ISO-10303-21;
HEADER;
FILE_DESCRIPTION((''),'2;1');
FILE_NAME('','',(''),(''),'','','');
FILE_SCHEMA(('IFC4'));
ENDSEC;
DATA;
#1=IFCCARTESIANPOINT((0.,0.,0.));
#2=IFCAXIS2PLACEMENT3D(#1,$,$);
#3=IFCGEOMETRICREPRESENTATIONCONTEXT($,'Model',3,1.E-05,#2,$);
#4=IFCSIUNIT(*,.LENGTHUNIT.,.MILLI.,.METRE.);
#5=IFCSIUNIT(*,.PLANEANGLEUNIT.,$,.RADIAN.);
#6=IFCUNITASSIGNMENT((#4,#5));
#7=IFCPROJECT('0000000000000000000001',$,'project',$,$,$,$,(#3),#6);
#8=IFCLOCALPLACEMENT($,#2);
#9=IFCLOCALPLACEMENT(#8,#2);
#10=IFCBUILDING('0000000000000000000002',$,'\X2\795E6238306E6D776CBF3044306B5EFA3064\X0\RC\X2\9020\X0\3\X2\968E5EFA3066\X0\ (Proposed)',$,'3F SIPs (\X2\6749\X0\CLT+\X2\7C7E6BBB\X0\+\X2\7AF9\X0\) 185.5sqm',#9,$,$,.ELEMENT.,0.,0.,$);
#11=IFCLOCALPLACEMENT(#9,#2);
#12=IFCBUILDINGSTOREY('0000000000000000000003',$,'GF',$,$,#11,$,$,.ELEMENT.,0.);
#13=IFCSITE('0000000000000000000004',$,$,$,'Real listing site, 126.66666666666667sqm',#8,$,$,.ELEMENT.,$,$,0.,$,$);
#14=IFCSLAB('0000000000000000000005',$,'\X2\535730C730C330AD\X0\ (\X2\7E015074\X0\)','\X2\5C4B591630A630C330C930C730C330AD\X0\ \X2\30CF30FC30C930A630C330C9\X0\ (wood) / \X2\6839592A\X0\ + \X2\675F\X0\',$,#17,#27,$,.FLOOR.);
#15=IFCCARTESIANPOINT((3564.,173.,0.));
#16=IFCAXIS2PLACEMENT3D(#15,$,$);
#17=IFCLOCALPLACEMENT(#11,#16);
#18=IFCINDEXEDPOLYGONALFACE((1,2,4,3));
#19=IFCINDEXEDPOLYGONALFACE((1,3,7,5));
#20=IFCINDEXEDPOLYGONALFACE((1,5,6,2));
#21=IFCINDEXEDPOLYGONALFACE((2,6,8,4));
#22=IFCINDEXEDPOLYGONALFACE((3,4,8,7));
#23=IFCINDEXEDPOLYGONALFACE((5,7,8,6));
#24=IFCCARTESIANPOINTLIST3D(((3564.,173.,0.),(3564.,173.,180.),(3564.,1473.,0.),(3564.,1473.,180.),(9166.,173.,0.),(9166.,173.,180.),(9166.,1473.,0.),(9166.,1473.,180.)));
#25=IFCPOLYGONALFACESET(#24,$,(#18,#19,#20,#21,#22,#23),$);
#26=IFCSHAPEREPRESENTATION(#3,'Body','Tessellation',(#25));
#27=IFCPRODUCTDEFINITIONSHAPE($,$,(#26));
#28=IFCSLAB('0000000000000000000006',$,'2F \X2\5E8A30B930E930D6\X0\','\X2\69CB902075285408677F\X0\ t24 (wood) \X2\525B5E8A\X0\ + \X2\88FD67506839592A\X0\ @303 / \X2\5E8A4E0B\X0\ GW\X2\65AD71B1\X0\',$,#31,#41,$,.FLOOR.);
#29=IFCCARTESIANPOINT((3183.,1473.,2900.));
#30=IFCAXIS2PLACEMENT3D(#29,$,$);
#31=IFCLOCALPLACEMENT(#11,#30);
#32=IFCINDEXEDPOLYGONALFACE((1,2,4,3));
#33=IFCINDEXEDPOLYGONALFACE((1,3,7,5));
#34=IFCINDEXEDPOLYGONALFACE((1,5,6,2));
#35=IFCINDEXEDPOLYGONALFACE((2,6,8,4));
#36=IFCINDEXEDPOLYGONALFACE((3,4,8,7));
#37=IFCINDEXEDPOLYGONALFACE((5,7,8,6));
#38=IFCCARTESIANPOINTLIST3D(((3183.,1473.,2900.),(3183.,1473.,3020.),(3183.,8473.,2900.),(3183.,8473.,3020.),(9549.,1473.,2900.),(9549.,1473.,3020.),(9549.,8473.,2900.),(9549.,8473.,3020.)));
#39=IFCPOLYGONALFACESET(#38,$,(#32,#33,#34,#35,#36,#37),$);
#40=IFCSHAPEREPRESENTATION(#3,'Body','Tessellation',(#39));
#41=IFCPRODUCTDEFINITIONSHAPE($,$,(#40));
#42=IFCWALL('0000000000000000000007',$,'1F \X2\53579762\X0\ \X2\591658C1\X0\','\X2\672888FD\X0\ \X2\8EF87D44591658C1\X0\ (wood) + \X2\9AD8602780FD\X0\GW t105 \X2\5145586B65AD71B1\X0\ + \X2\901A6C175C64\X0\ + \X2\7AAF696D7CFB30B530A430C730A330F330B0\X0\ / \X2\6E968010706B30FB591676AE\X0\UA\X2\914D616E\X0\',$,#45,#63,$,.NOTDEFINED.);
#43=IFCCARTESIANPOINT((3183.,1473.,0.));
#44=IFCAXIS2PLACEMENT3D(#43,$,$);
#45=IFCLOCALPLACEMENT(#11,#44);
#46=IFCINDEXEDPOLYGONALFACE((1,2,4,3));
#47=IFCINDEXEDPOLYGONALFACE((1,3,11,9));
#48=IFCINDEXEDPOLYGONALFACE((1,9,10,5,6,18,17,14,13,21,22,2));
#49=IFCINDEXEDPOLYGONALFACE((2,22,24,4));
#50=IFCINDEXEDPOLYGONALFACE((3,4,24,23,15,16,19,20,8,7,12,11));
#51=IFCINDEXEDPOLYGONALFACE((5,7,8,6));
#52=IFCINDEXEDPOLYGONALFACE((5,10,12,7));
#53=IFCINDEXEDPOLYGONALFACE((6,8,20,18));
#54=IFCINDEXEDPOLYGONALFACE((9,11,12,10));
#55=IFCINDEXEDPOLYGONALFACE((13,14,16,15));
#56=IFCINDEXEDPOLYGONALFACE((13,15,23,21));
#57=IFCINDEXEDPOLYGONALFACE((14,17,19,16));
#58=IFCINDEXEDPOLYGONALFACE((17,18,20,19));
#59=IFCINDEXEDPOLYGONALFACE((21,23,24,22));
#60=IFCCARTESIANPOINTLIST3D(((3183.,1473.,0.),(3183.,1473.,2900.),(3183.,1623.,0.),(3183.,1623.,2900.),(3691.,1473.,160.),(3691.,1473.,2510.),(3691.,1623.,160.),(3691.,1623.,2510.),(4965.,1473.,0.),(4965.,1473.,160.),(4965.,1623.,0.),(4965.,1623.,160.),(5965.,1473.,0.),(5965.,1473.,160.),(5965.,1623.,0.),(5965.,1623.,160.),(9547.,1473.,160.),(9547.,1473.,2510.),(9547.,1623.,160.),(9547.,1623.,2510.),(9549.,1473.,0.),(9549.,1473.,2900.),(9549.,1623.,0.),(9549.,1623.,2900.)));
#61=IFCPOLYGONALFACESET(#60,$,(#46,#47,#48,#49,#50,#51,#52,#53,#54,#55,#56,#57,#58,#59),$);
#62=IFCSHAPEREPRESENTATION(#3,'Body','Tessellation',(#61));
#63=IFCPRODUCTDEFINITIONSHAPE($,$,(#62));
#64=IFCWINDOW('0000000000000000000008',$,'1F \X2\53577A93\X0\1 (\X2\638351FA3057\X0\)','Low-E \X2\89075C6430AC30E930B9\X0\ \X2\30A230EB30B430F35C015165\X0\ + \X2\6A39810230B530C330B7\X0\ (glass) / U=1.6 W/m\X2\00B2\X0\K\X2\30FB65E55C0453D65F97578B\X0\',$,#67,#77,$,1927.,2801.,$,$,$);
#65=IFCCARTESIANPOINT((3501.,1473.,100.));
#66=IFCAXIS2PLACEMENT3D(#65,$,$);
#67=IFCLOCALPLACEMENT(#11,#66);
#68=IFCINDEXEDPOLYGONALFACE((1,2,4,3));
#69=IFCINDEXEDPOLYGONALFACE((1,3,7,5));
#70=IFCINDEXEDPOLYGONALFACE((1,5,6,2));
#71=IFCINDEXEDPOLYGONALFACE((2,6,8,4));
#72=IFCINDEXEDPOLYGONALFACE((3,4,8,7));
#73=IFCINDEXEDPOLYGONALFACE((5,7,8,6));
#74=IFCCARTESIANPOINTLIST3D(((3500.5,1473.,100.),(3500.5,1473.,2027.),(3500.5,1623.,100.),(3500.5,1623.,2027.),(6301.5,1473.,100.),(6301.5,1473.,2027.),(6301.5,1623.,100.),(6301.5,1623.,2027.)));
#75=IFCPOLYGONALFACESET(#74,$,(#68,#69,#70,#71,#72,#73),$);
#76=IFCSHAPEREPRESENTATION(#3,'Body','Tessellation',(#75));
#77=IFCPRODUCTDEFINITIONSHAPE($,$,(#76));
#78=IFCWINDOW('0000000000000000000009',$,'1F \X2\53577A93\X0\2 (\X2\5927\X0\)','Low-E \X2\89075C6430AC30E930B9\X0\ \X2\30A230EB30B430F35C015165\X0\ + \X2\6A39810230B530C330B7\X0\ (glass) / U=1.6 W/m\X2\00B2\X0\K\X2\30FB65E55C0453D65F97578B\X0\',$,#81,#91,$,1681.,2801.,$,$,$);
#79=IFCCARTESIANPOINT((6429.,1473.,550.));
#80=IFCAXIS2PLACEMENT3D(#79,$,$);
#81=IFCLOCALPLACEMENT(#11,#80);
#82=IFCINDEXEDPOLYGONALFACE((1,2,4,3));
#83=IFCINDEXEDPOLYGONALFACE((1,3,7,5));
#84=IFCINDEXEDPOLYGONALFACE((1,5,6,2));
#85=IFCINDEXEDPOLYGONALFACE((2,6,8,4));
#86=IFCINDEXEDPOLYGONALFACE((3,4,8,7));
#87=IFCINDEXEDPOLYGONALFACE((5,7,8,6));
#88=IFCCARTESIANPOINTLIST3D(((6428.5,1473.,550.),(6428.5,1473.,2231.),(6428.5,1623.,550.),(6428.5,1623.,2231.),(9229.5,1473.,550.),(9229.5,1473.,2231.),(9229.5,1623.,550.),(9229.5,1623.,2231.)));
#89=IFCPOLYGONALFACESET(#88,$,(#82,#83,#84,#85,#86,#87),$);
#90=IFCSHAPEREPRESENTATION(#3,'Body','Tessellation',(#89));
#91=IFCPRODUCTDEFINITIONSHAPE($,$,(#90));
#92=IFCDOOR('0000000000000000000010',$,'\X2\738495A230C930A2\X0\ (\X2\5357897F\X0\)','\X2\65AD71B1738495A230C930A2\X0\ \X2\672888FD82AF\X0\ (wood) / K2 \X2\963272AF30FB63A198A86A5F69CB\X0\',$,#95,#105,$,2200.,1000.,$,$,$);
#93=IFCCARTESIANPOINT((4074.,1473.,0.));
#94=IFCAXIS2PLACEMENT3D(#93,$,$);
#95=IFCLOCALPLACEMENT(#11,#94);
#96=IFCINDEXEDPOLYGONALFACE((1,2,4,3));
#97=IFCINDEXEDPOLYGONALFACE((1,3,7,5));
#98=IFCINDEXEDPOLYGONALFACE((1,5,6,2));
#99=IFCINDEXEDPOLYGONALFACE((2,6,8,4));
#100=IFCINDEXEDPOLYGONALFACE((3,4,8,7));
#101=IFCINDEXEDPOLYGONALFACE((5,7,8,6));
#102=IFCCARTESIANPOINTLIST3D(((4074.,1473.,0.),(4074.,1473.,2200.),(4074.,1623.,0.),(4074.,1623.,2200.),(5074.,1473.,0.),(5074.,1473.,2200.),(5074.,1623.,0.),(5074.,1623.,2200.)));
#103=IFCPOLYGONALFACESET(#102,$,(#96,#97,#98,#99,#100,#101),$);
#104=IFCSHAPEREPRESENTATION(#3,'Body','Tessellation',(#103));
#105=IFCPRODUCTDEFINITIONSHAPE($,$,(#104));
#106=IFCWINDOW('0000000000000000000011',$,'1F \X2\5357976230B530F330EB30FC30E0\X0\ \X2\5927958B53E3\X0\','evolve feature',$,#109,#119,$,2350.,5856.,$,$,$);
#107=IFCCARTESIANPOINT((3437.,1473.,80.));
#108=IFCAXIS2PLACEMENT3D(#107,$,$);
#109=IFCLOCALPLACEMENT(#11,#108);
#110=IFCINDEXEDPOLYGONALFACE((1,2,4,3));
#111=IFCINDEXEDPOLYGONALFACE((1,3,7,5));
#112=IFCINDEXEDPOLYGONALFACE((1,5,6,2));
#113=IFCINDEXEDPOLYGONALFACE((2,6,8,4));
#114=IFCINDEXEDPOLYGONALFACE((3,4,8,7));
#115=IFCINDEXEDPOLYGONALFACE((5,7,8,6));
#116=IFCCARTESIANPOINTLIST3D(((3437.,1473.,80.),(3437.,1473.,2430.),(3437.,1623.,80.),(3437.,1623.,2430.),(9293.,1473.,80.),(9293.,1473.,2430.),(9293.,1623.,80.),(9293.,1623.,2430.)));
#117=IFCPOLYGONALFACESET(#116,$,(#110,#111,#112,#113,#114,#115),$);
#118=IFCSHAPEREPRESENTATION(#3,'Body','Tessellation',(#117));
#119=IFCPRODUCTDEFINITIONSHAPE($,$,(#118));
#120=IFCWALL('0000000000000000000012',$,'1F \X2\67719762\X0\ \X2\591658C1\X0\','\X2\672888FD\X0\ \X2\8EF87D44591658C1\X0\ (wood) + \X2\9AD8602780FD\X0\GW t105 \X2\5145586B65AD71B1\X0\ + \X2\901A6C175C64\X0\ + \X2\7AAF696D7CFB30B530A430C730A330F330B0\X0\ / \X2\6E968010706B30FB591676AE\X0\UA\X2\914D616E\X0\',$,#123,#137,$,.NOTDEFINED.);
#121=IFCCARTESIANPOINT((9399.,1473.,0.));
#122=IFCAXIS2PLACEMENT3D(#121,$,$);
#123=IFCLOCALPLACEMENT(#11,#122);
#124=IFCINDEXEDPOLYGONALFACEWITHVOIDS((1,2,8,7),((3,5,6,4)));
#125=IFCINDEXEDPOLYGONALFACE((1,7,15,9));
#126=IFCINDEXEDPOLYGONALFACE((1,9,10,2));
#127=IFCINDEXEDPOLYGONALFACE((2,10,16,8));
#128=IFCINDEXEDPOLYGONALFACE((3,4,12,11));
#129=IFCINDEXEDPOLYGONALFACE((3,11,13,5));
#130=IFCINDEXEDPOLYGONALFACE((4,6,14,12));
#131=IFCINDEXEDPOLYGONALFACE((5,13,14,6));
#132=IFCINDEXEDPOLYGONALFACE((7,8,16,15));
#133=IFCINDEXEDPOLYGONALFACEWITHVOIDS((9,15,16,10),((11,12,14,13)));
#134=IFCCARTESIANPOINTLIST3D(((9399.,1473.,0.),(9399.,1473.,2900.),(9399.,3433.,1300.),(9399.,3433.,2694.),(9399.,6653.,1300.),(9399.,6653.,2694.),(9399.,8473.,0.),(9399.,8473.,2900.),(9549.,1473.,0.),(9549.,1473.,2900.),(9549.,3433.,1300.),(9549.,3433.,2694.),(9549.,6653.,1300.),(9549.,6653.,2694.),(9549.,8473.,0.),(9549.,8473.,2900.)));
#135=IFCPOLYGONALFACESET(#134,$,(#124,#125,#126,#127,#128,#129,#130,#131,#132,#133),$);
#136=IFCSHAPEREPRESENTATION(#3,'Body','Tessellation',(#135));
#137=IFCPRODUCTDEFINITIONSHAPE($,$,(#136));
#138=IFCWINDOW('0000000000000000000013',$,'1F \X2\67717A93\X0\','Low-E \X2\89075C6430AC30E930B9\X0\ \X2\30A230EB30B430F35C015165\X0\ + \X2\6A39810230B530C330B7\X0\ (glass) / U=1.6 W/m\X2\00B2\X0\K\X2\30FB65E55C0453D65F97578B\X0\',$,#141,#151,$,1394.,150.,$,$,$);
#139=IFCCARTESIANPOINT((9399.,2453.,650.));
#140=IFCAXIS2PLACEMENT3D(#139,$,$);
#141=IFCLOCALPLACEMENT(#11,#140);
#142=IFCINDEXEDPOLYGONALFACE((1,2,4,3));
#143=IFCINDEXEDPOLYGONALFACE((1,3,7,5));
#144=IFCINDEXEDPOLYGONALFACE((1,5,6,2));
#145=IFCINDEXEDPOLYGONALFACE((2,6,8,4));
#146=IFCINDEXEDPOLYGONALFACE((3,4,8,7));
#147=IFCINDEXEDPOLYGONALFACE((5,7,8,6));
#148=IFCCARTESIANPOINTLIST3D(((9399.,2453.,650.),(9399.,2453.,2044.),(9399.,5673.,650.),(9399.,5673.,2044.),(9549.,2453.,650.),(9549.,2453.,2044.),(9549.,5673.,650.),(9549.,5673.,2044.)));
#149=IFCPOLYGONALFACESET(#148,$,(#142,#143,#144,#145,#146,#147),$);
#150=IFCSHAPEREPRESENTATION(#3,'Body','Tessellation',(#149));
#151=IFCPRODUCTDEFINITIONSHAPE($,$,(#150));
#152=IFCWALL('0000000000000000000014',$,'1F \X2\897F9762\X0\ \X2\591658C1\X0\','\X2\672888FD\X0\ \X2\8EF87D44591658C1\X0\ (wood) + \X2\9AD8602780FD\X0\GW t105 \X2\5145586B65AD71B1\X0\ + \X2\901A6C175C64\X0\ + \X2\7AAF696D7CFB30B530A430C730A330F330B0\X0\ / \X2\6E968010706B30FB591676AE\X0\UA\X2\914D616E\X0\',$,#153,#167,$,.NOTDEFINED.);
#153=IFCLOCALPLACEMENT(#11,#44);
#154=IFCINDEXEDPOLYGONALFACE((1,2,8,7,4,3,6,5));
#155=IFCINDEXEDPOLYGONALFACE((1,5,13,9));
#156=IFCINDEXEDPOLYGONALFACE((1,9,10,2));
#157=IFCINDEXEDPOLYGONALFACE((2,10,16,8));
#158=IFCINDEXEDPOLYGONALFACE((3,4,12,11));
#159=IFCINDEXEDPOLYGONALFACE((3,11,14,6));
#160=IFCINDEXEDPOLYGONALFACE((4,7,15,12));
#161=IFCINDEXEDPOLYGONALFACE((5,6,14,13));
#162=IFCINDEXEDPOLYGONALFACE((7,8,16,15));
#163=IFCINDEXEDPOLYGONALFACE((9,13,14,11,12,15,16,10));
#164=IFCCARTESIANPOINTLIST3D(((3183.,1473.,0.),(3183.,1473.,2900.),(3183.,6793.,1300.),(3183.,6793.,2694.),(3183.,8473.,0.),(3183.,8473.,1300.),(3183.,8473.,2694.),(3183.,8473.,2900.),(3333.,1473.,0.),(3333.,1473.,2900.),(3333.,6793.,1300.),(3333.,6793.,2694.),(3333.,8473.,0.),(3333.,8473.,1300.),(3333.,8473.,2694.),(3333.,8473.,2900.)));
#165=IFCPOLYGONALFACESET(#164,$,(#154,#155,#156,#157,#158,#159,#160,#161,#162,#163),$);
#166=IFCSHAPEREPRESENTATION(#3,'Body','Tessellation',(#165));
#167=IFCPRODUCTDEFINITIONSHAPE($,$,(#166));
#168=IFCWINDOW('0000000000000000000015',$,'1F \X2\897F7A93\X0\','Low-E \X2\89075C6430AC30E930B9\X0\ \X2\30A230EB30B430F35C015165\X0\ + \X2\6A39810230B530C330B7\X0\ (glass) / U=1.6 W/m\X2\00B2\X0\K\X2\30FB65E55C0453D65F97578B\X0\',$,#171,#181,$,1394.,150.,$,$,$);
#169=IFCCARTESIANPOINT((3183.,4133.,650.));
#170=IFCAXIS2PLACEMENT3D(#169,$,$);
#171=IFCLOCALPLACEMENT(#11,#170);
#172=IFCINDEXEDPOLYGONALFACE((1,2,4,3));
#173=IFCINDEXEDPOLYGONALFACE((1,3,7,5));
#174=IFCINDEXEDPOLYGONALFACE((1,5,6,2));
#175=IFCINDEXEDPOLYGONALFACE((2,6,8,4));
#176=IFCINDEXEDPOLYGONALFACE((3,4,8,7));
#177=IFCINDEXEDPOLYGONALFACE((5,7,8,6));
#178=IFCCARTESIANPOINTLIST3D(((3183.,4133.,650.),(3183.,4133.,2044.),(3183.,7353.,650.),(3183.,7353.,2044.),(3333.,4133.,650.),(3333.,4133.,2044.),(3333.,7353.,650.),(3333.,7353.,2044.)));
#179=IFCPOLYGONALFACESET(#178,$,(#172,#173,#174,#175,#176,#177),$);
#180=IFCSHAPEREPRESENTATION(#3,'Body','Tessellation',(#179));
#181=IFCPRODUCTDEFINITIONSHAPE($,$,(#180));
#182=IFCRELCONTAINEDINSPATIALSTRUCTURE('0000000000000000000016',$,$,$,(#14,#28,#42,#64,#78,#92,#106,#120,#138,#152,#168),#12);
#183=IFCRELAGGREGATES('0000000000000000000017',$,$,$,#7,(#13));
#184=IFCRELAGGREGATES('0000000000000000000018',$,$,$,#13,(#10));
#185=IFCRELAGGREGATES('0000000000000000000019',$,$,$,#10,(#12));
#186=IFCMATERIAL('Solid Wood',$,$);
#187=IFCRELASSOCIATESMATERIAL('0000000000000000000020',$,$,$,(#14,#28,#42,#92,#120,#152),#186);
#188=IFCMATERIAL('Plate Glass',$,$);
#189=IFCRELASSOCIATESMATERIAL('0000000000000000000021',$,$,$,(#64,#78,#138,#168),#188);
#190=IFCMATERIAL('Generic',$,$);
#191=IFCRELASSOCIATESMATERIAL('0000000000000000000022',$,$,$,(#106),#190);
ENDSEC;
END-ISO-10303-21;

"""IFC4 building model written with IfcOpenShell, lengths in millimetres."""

from ifc_helpers import new_model, si_unit, frame, frame_2d, origin, place, context, project, spatial, rectangle, extrude, material, element, fill, save


model = new_model("IFC4")

# Units and contexts
model_context = context("Model", 3, precision=1e-05, world=origin())
ifc_project = project(units=[si_unit("LENGTHUNIT", "METRE", prefix="MILLI"), si_unit("PLANEANGLEUNIT", "RADIAN")], contexts=[model_context])

# Site, building, storey
site_placement = place(None, origin())
site = spatial("IfcSite", under=ifc_project, at=site_placement, ObjectType="Real listing site, 126.66666666666667sqm", CompositionType="ELEMENT", RefElevation=0.0)
building_placement = place(site_placement, origin())
building = spatial("IfcBuilding", under=site, at=building_placement, Name="神戸の海沿いに建つRC造3階建て (Proposed)", ObjectType="3F SIPs (杉CLT+籾殻+竹) 185.5sqm", CompositionType="ELEMENT", ElevationOfRefHeight=0.0, ElevationOfTerrain=0.0)
storey_placement = place(building_placement, origin())
storey = spatial("IfcBuildingStorey", under=building, at=storey_placement, Name="GF", CompositionType="ELEMENT", Elevation=0.0)

# Slabs
ifc_material_1 = material(Name="Solid Wood")
slab_1_placement = place(storey_placement, frame((3564.0, 173.0, 0.0)))
element("IfcSlab", 1, at=slab_1_placement, inside=storey, material=ifc_material_1, Name="南デッキ (縁側)", Description="屋外ウッドデッキ ハードウッド (wood) / 根太 + 束", PredefinedType="FLOOR", context=model_context, shape_type="SweptSolid", body=[
    extrude(rectangle(XDim=5602.0, YDim=1300.0, at=frame_2d((2801.0, 650.0))), frame((3564.0, 173.0, 0.0)), (0.0, 0.0, 1.0), 180.0),
])
slab_2_placement = place(storey_placement, frame((3183.0, 1473.0, 2900.0)))
element("IfcSlab", 2, at=slab_2_placement, inside=storey, material=ifc_material_1, Name="2F 床スラブ", Description="構造用合板 t24 (wood) 剛床 + 製材根太 @303 / 床下 GW断熱", PredefinedType="FLOOR", context=model_context, shape_type="SweptSolid", body=[
    extrude(rectangle(XDim=6366.0, YDim=7000.0, at=frame_2d((3183.0, 3500.0))), frame((3183.0, 1473.0, 2900.0)), (0.0, 0.0, 1.0), 120.0),
])

# Wall, openings, windows, door
wall_1_placement = place(storey_placement, frame((3183.0, 1473.0, 0.0)))
wall_1 = element("IfcWall", 3, at=wall_1_placement, inside=storey, material=ifc_material_1, Name="1F 南面 外壁", Description="木製 軸組外壁 (wood) + 高性能GW t105 充填断熱 + 通気層 + 窯業系サイディング / 準耐火・外皮UA配慮", PredefinedType="NOTDEFINED", context=model_context, shape_type="SweptSolid", body=[
    extrude(rectangle(XDim=6366.0, YDim=150.0, at=frame_2d((3183.0, 75.0))), frame((3183.0, 1473.0, 0.0)), (0.0, 0.0, 1.0), 2900.0),
])
opening_1_placement = place(storey_placement, frame((3501.0, 1473.0, 100.0)))
opening_1 = element("IfcOpeningElement", 4, at=opening_1_placement, cuts=wall_1, PredefinedType="NOTDEFINED", context=model_context, shape_type="SweptSolid", body=[
    extrude(rectangle(XDim=2801.0, YDim=150.0, at=frame_2d((1400.0, 75.0))), frame((3501.0, 1473.0, 100.0)), (0.0, 0.0, 1.0), 1927.0),
])
opening_2_placement = place(storey_placement, frame((6429.0, 1473.0, 550.0)))
opening_2 = element("IfcOpeningElement", 5, at=opening_2_placement, cuts=wall_1, PredefinedType="NOTDEFINED", context=model_context, shape_type="SweptSolid", body=[
    extrude(rectangle(XDim=2801.0, YDim=150.0, at=frame_2d((1400.0, 75.0))), frame((6429.0, 1473.0, 550.0)), (0.0, 0.0, 1.0), 1681.0),
])
opening_3_placement = place(storey_placement, frame((4074.0, 1473.0, 0.0)))
opening_3 = element("IfcOpeningElement", 6, at=opening_3_placement, cuts=wall_1, PredefinedType="NOTDEFINED", context=model_context, shape_type="SweptSolid", body=[
    extrude(rectangle(XDim=1000.0, YDim=150.0, at=frame_2d((500.0, 75.0))), frame((4074.0, 1473.0, 0.0)), (0.0, 0.0, 1.0), 2200.0),
])
opening_4_placement = place(storey_placement, frame((3437.0, 1473.0, 80.0)))
opening_4 = element("IfcOpeningElement", 7, at=opening_4_placement, cuts=wall_1, PredefinedType="NOTDEFINED", context=model_context, shape_type="SweptSolid", body=[
    extrude(rectangle(XDim=5856.0, YDim=150.0, at=frame_2d((2928.0, 75.0))), frame((3437.0, 1473.0, 80.0)), (0.0, 0.0, 1.0), 2350.0),
])
ifc_material_2 = material(Name="Plate Glass")
window_1_placement = place(storey_placement, frame((3501.0, 1473.0, 100.0)))
window_1 = element("IfcWindow", 8, at=window_1_placement, inside=storey, material=ifc_material_2, Name="1F 南窓1 (掃出し)", Description="Low-E 複層ガラス アルゴン封入 + 樹脂サッシ (glass) / U=1.6 W/m²K・日射取得型", OverallHeight=1927.0, OverallWidth=2801.0, context=model_context, shape_type="SweptSolid", body=[
    extrude(rectangle(XDim=2801.0, YDim=150.0, at=frame_2d((1400.0, 75.0))), frame((3501.0, 1473.0, 100.0)), (0.0, 0.0, 1.0), 1927.0),
])
fill(opening_1, window_1)
window_2_placement = place(storey_placement, frame((6429.0, 1473.0, 550.0)))
window_2 = element("IfcWindow", 9, at=window_2_placement, inside=storey, material=ifc_material_2, Name="1F 南窓2 (大)", Description="Low-E 複層ガラス アルゴン封入 + 樹脂サッシ (glass) / U=1.6 W/m²K・日射取得型", OverallHeight=1681.0, OverallWidth=2801.0, context=model_context, shape_type="SweptSolid", body=[
    extrude(rectangle(XDim=2801.0, YDim=150.0, at=frame_2d((1400.0, 75.0))), frame((6429.0, 1473.0, 550.0)), (0.0, 0.0, 1.0), 1681.0),
])
fill(opening_2, window_2)
door_placement = place(storey_placement, frame((4074.0, 1473.0, 0.0)))
door = element("IfcDoor", 10, at=door_placement, inside=storey, material=ifc_material_1, Name="玄関ドア (南西)", Description="断熱玄関ドア 木製芯 (wood) / K2 防犯・採風機構", OverallHeight=2200.0, OverallWidth=1000.0, context=model_context, shape_type="SweptSolid", body=[
    extrude(rectangle(XDim=1000.0, YDim=150.0, at=frame_2d((500.0, 75.0))), frame((4074.0, 1473.0, 0.0)), (0.0, 0.0, 1.0), 2200.0),
])
fill(opening_3, door)
ifc_material_3 = material(Name="Generic")
window_3_placement = place(storey_placement, frame((3437.0, 1473.0, 80.0)))
window_3 = element("IfcWindow", 11, at=window_3_placement, inside=storey, material=ifc_material_3, Name="1F 南面サンルーム 大開口", Description="evolve feature", OverallHeight=2350.0, OverallWidth=5856.0, context=model_context, shape_type="SweptSolid", body=[
    extrude(rectangle(XDim=5856.0, YDim=150.0, at=frame_2d((2928.0, 75.0))), frame((3437.0, 1473.0, 80.0)), (0.0, 0.0, 1.0), 2350.0),
])
fill(opening_4, window_3)

# Walls, openings, windows
wall_2_placement = place(storey_placement, frame((9399.0, 1473.0, 0.0)))
wall_2 = element("IfcWall", 12, at=wall_2_placement, inside=storey, material=ifc_material_1, Name="1F 東面 外壁", Description="木製 軸組外壁 (wood) + 高性能GW t105 充填断熱 + 通気層 + 窯業系サイディング / 準耐火・外皮UA配慮", PredefinedType="NOTDEFINED", context=model_context, shape_type="SweptSolid", body=[
    extrude(rectangle(XDim=150.0, YDim=7000.0, at=frame_2d((75.0, 3500.0))), frame((9399.0, 1473.0, 0.0)), (0.0, 0.0, 1.0), 2900.0),
])
opening_5_placement = place(storey_placement, frame((9399.0, 2453.0, 650.0)))
opening_5 = element("IfcOpeningElement", 13, at=opening_5_placement, cuts=wall_2, PredefinedType="NOTDEFINED", context=model_context, shape_type="SweptSolid", body=[
    extrude(rectangle(XDim=150.0, YDim=3220.0, at=frame_2d((75.0, 1610.0))), frame((9399.0, 2453.0, 650.0)), (0.0, 0.0, 1.0), 1394.0),
])
window_4_placement = place(storey_placement, frame((9399.0, 2453.0, 650.0)))
window_4 = element("IfcWindow", 14, at=window_4_placement, inside=storey, material=ifc_material_2, Name="1F 東窓", Description="Low-E 複層ガラス アルゴン封入 + 樹脂サッシ (glass) / U=1.6 W/m²K・日射取得型", OverallHeight=1394.0, OverallWidth=150.0, context=model_context, shape_type="SweptSolid", body=[
    extrude(rectangle(XDim=150.0, YDim=3220.0, at=frame_2d((75.0, 1610.0))), frame((9399.0, 2453.0, 650.0)), (0.0, 0.0, 1.0), 1394.0),
])
fill(opening_5, window_4)
wall_3_placement = place(storey_placement, frame((3183.0, 1473.0, 0.0)))
wall_3 = element("IfcWall", 15, at=wall_3_placement, inside=storey, material=ifc_material_1, Name="1F 西面 外壁", Description="木製 軸組外壁 (wood) + 高性能GW t105 充填断熱 + 通気層 + 窯業系サイディング / 準耐火・外皮UA配慮", PredefinedType="NOTDEFINED", context=model_context, shape_type="SweptSolid", body=[
    extrude(rectangle(XDim=150.0, YDim=7000.0, at=frame_2d((75.0, 3500.0))), frame((3183.0, 1473.0, 0.0)), (0.0, 0.0, 1.0), 2900.0),
])
opening_6_placement = place(storey_placement, frame((3183.0, 4133.0, 650.0)))
opening_6 = element("IfcOpeningElement", 16, at=opening_6_placement, cuts=wall_3, PredefinedType="NOTDEFINED", context=model_context, shape_type="SweptSolid", body=[
    extrude(rectangle(XDim=150.0, YDim=3220.0, at=frame_2d((75.0, 1610.0))), frame((3183.0, 4133.0, 650.0)), (0.0, 0.0, 1.0), 1394.0),
])
window_5_placement = place(storey_placement, frame((3183.0, 4133.0, 650.0)))
window_5 = element("IfcWindow", 17, at=window_5_placement, inside=storey, material=ifc_material_2, Name="1F 西窓", Description="Low-E 複層ガラス アルゴン封入 + 樹脂サッシ (glass) / U=1.6 W/m²K・日射取得型", OverallHeight=1394.0, OverallWidth=150.0, context=model_context, shape_type="SweptSolid", body=[
    extrude(rectangle(XDim=150.0, YDim=3220.0, at=frame_2d((75.0, 1610.0))), frame((3183.0, 4133.0, 650.0)), (0.0, 0.0, 1.0), 1394.0),
])
fill(opening_6, window_5)

save(model, "model.ifc")
